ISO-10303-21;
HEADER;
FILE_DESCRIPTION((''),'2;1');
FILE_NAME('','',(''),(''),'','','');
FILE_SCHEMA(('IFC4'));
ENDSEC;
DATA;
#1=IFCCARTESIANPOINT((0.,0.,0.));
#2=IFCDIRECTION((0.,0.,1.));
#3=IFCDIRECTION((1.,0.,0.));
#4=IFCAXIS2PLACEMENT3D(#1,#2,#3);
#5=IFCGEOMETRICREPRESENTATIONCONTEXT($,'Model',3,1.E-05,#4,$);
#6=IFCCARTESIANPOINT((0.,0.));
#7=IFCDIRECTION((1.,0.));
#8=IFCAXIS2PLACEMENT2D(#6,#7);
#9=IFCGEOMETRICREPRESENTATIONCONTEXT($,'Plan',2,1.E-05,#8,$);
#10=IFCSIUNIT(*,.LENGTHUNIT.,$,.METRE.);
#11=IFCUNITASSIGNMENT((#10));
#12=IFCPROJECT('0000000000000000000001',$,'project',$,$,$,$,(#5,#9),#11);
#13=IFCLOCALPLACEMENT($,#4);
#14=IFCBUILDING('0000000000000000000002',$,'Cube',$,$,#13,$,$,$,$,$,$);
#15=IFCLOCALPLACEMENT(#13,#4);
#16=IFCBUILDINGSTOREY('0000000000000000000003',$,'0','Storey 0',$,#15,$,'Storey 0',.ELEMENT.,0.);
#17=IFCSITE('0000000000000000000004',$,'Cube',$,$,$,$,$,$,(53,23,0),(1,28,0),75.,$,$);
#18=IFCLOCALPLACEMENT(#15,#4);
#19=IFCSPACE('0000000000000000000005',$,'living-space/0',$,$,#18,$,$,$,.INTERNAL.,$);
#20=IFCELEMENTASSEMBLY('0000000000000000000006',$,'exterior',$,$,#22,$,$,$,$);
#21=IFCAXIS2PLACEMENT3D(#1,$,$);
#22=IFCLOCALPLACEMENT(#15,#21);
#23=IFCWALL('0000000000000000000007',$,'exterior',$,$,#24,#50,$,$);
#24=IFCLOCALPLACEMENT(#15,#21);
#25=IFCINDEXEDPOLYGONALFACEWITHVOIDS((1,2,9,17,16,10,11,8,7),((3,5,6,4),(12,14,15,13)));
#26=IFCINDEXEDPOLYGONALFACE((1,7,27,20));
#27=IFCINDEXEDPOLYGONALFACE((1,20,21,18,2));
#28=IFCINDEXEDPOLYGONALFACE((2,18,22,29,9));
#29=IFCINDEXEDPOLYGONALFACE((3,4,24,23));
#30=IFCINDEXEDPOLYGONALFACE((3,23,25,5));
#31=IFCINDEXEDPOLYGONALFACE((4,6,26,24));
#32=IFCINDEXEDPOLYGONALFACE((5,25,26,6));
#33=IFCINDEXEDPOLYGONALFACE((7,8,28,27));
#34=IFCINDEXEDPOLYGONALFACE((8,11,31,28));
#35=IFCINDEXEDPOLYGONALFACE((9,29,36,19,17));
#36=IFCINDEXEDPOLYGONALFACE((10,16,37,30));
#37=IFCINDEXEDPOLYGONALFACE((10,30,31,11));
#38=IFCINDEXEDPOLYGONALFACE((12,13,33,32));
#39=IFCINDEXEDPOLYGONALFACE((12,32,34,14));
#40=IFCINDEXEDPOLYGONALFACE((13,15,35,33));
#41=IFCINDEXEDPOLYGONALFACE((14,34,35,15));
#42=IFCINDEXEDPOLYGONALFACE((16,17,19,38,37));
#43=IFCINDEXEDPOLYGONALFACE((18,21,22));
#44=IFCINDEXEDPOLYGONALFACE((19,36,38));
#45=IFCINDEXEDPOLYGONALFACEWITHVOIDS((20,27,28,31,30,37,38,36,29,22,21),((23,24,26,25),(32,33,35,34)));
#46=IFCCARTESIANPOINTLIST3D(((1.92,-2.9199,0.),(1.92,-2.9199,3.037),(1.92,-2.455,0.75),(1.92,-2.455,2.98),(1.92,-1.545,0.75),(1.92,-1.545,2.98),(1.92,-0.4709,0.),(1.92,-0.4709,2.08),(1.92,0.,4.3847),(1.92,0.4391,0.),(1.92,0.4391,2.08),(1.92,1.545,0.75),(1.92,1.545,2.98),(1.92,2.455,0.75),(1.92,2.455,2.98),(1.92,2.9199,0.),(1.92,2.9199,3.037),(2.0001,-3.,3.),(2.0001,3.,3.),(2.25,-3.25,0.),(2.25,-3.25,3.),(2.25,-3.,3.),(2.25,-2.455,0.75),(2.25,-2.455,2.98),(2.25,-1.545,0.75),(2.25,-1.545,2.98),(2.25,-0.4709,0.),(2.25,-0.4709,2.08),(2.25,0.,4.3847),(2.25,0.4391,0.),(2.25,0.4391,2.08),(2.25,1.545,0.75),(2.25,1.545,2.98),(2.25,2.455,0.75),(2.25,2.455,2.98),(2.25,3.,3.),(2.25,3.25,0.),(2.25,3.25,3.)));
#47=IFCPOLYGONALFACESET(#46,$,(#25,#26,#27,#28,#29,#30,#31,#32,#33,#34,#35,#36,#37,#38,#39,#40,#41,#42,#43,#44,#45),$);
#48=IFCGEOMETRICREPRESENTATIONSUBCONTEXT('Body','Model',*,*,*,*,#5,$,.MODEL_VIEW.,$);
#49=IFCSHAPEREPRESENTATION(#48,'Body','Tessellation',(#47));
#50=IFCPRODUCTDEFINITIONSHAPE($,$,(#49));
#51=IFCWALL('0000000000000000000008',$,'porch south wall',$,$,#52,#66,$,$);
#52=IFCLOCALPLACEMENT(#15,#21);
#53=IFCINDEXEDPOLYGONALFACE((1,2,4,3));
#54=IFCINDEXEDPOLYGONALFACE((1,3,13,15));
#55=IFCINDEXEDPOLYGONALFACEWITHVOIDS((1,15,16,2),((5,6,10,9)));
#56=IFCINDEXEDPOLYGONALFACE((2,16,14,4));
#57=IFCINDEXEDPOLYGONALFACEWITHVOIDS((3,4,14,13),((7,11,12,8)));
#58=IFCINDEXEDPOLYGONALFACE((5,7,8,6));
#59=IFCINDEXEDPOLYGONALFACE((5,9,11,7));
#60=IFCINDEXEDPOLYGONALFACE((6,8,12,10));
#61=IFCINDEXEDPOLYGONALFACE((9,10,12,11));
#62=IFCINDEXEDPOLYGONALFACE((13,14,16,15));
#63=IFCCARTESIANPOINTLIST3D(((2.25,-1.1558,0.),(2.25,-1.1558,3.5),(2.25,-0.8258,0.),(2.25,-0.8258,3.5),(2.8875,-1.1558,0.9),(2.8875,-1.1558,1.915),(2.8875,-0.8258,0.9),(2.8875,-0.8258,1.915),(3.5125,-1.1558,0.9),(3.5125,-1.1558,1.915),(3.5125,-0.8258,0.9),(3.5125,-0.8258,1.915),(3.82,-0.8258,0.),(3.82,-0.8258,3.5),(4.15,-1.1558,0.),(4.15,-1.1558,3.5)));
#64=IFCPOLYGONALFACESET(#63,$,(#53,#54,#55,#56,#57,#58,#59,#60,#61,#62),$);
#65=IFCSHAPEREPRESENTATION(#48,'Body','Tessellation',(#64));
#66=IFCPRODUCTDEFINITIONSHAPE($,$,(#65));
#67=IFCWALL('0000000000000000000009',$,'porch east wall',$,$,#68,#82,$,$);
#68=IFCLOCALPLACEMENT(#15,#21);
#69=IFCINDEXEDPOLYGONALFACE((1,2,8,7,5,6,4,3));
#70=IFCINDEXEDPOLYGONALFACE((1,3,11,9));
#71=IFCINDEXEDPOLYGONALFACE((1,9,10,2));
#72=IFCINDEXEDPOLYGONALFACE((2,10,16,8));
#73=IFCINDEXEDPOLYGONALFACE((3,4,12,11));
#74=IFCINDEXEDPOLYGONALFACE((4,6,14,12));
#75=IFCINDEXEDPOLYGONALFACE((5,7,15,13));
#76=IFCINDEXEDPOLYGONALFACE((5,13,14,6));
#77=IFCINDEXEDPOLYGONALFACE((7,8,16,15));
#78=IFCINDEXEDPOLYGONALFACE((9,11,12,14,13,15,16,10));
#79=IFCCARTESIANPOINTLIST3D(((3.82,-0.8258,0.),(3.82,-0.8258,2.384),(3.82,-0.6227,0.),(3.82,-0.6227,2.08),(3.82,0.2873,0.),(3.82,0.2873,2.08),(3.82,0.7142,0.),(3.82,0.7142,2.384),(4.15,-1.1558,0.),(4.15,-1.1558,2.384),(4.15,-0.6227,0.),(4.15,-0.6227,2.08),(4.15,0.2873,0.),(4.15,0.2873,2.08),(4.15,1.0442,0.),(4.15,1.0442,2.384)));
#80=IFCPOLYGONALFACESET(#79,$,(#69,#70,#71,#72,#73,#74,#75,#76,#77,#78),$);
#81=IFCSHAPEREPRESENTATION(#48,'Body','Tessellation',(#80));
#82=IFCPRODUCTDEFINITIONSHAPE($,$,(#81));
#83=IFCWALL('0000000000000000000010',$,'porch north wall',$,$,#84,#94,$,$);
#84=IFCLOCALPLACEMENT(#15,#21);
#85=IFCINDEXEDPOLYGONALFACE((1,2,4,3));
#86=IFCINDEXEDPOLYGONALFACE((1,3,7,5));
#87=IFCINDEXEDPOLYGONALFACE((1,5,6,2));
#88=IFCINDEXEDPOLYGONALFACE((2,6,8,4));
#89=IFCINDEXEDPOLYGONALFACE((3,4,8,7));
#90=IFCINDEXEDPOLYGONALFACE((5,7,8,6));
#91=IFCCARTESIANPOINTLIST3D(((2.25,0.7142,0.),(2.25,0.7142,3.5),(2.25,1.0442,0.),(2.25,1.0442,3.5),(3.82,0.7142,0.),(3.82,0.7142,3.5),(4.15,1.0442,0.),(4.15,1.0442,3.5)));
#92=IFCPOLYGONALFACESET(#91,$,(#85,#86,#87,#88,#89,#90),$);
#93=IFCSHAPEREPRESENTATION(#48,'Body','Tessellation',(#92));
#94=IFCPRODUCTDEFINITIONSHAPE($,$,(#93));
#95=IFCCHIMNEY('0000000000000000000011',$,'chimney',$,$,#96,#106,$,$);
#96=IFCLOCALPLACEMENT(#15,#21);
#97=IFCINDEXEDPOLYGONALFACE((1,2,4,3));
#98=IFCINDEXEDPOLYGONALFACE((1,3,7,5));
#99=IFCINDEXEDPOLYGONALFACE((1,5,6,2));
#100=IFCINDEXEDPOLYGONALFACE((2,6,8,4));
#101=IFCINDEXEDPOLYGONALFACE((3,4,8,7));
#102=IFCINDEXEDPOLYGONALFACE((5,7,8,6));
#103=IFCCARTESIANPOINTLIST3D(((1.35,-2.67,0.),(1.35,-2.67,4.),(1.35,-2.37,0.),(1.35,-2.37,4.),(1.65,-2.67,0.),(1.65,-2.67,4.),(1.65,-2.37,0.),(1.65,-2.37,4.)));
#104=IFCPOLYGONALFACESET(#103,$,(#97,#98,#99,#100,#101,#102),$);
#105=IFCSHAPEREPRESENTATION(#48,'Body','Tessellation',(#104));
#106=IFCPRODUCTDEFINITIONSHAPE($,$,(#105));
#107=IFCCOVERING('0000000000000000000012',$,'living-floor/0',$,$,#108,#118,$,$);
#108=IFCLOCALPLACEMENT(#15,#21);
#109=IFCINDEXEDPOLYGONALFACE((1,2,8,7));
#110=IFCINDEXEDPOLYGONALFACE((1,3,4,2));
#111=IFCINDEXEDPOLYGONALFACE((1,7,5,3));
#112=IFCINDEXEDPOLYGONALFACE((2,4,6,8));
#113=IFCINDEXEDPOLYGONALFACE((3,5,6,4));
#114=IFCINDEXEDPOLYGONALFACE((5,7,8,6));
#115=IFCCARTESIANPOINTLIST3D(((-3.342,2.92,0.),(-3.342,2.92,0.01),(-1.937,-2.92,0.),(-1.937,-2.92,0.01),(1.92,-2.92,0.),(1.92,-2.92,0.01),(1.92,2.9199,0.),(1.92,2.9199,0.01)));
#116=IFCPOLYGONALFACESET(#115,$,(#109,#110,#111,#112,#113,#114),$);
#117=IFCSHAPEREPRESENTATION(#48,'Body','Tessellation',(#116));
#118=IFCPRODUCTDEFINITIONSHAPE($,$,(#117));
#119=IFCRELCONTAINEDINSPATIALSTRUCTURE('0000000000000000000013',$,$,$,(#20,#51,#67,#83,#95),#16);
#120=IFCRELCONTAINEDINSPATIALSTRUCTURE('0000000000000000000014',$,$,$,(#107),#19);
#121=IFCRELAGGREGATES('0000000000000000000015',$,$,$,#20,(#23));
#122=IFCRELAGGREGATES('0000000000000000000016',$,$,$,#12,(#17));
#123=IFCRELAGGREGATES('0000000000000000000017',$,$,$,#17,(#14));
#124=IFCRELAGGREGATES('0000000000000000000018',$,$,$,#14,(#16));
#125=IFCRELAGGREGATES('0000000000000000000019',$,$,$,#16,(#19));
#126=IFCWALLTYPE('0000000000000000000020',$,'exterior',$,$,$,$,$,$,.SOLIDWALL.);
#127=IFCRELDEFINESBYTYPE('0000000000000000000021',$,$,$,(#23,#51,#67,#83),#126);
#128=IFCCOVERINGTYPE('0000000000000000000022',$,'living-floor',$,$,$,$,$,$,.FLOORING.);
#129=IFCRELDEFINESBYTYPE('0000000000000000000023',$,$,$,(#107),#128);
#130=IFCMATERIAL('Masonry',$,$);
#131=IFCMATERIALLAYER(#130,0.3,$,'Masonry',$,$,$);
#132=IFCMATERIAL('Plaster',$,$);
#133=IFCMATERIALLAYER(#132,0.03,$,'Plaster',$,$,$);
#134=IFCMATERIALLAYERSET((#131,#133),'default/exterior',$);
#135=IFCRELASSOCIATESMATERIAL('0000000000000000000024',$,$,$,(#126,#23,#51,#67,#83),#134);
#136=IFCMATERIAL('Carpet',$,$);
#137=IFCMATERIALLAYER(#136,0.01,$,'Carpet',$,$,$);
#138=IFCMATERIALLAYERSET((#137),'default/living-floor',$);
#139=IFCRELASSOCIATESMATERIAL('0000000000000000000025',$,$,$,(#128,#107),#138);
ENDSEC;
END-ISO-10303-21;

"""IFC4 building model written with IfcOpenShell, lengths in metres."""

from ifc_helpers import new_model, si_unit, frame, origin, origin_with_axes, origin_2d_with_axis, place, context, subcontext, project, spatial, polyline, line, indexed_curve, outline, extrude, clip, bounded_halfspace, source, transform, mapped, material, layer, layer_set, layer_usage, type_object, element, aggregate, save


model = new_model("IFC4")

# Units and contexts
model_context = context("Model", 3, precision=1e-05, world=origin_with_axes())
plan_context = context("Plan", 2, precision=1e-05, world=origin_2d_with_axis())
body_context_1 = subcontext(model_context, "Body", "Model", "MODEL_VIEW")
ifc_project = project(units=[si_unit("LENGTHUNIT", "METRE")], contexts=[model_context, plan_context])

# Site, building, storey
site = spatial("IfcSite", under=ifc_project, Name="Cube", RefLatitude=(53, 23, 0), RefLongitude=(1, 28, 0), RefElevation=75.0)
building_placement = place(None, origin_with_axes())
building = spatial("IfcBuilding", under=site, at=building_placement, Name="Cube")
storey_placement = place(building_placement, origin_with_axes())
storey = spatial("IfcBuildingStorey", under=building, at=storey_placement, Name="0", Description="Storey 0", LongName="Storey 0", CompositionType="ELEMENT", Elevation=0.0)

# Element assembly, wall, openings
ifc_material_1 = material(Name="Masonry")
ifc_layer_1 = layer(ifc_material_1, 0.3, Name="Masonry")
ifc_material_2 = material(Name="Plaster")
ifc_layer_2 = layer(ifc_material_2, 0.03, Name="Plaster")
ifc_layer_set_1 = layer_set([ifc_layer_1, ifc_layer_2], Name="default/exterior")
wall_type = type_object("IfcWallType", Name="exterior", PredefinedType="SOLIDWALL", material=ifc_layer_set_1)
assembly_1_placement = place(storey_placement, frame((2.0, -3.0, 0.0), z_axis=(0.0, 0.0, 1.0), x_axis=(0.0, 1.0, 0.0)))
assembly_1 = element("IfcElementAssembly", 1, at=assembly_1_placement, inside=storey, Name="exterior")
ifc_layer_usage_1 = layer_usage(ifc_layer_set_1, "AXIS2", "POSITIVE", -0.25)
wall_1_placement = place(assembly_1_placement, origin_with_axes())
wall_1 = element("IfcWall", 2, at=wall_1_placement, type_object=wall_type, material=ifc_layer_usage_1, Name="exterior", context=body_context_1, shape_type="Clipping", body=[
    clip(clip(clip(clip(extrude(outline(polyline([(0.0801, 0.08), (-0.25, -0.25), (6.25, -0.25), (5.9199, 0.08), (0.0801, 0.08)])), origin(), (0.0, 0.0, 1.0), 4.385), bounded_halfspace(frame((6.0, 0.0, 3.0), z_axis=(0.419069, 0.0, 0.907954), x_axis=(0.0, -1.0, 0.0)), False, origin(), polyline([(6.0, -1.0), (3.0, -1.0), (3.0, 1.0), (6.0, 1.0), (6.0, -1.0)]))), bounded_halfspace(frame((6.0, 0.0, 3.0), z_axis=(0.0, 0.0, 1.0), x_axis=(0.0, 1.0, 0.0)), False, origin(), polyline([(6.0, 1.0), (7.0, 1.0), (7.0, -1.0), (6.0, -1.0), (6.0, 1.0)]))), bounded_halfspace(frame((3.0, 0.0, 4.3847), z_axis=(-0.419069, 0.0, 0.907954), x_axis=(0.0, -1.0, 0.0)), False, origin(), polyline([(3.0, -1.0), (0.0, -1.0), (0.0, 1.0), (3.0, 1.0), (3.0, -1.0)]))), bounded_halfspace(frame((0.0, 0.0, 3.0), z_axis=(0.0, 0.0, 1.0), x_axis=(0.0, -1.0, 0.0)), False, origin(), polyline([(0.0, -1.0), (-1.0, -1.0), (-1.0, 1.0), (0.0, 1.0), (0.0, -1.0)]))),
])
opening_1_placement = place(wall_1_placement, frame((0.545, -0.25, 0.75), z_axis=(0.0, 0.0, 1.0), x_axis=(1.0, 0.0, 0.0)))
element("IfcOpeningElement", 3, at=opening_1_placement, cuts=wall_1, PredefinedType="OPENING", context=body_context_1, shape_type="SweptSolid", body=[
    extrude(outline(polyline([(0.0, -0.02), (0.91, -0.02), (0.91, 0.35), (0.0, 0.35), (0.0, -0.02)])), origin(), (0.0, 0.0, 1.0), 2.23),
])
opening_2_placement = place(wall_1_placement, frame((4.545, -0.25, 0.75), z_axis=(0.0, 0.0, 1.0), x_axis=(1.0, 0.0, 0.0)))
element("IfcOpeningElement", 4, at=opening_2_placement, cuts=wall_1, PredefinedType="OPENING", context=body_context_1, shape_type="SweptSolid", body=[
    extrude(outline(polyline([(0.0, -0.02), (0.91, -0.02), (0.91, 0.35), (0.0, 0.35), (0.0, -0.02)])), origin(), (0.0, 0.0, 1.0), 2.23),
])
shared_shape_1 = source(origin_with_axes(), body_context_1, "Body", "SweptSolid", [
    extrude(outline(indexed_curve([(0.0, 0.0), (0.91, 0.0), (0.91, 2.08), (0.0, 2.08)], segments=[line(1, 2, 3, 4, 1)])), frame((0.0, -0.6, 0.0), z_axis=(0.0, -1.0, 0.0), x_axis=(1.0, 0.0, 0.0)), (0.0, 0.0, -1.0), 1.2),
])
opening_3_placement = place(wall_1_placement, frame((2.5291, -0.25, 0.0), z_axis=(0.0, 0.0, 1.0), x_axis=(1.0, 0.0, 0.0)))
element("IfcOpeningElement", 5, at=opening_3_placement, cuts=wall_1, PredefinedType="OPENING", context=body_context_1, shape_type="MappedRepresentation", body=[
    mapped(shared_shape_1, transform((0.0, 0.0, 0.0), x_axis=(1.0, 0.0, 0.0), y_axis=(0.0, 1.0, 0.0), z_axis=(0.0, 0.0, 1.0), scale=1.0)),
])
aggregate(assembly_1, [wall_1])

# Walls, openings
ifc_layer_usage_2 = layer_usage(ifc_layer_set_1, "AXIS2", "POSITIVE", 0.0)
wall_2_placement = place(storey_placement, frame((2.25, -1.1558, 0.0), z_axis=(0.0, 0.0, 1.0), x_axis=(1.0, 0.0, 0.0)))
wall_2 = element("IfcWall", 6, at=wall_2_placement, inside=storey, type_object=wall_type, material=ifc_layer_usage_2, Name="porch south wall", context=body_context_1, shape_type="SweptSolid", body=[
    extrude(outline(indexed_curve([(0.0, 0.0), (0.0, 0.33), (1.57, 0.33), (1.9, 0.0)], segments=[line(1, 2, 3, 4, 1)])), origin_with_axes(), (0.0, 0.0, 1.0), 3.5),
])
opening_4_placement = place(wall_2_placement, frame((0.6375, -0.0002, 0.9), z_axis=(0.0, 0.0, 1.0), x_axis=(1.0, 0.0, 0.0)))
element("IfcOpeningElement", 7, at=opening_4_placement, cuts=wall_2, context=body_context_1, shape_type="SweptSolid", body=[
    extrude(outline(indexed_curve([(0.0, 0.0), (0.0, 0.5), (0.625, 0.5), (0.625, 0.0), (0.0, 0.0)], self_intersect=False)), origin_with_axes(), (0.0, 0.0, 1.0), 1.015),
])
ifc_layer_usage_3 = layer_usage(ifc_layer_set_1, "AXIS2", "POSITIVE", 0.0)
wall_3_placement = place(storey_placement, frame((4.15, -1.1558, 0.0), z_axis=(0.0, 0.0, 1.0), x_axis=(0.0, 1.0, 0.0)))
wall_3 = element("IfcWall", 8, at=wall_3_placement, inside=storey, type_object=wall_type, material=ifc_layer_usage_3, Name="porch east wall", context=body_context_1, shape_type="SweptSolid", body=[
    extrude(outline(indexed_curve([(0.0, 0.0), (0.33, 0.33), (1.87, 0.33), (2.2, 0.0)], segments=[line(1, 2, 3, 4, 1)])), origin_with_axes(), (0.0, 0.0, 1.0), 2.384),
])
shared_shape_2 = source(origin_with_axes(), body_context_1, "Body", "SweptSolid", [
    extrude(outline(indexed_curve([(0.0, 0.0), (0.91, 0.0), (0.91, 2.08), (0.0, 2.08)], segments=[line(1, 2, 3, 4, 1)])), frame((0.0, -0.6, 0.0), z_axis=(0.0, -1.0, 0.0), x_axis=(1.0, 0.0, 0.0)), (0.0, 0.0, -1.0), 1.2),
])
opening_5_placement = place(wall_3_placement, frame((0.5331, 0.0, 0.0), z_axis=(0.0, 0.0, 1.0), x_axis=(1.0, 0.0, 0.0)))
element("IfcOpeningElement", 9, at=opening_5_placement, cuts=wall_3, PredefinedType="OPENING", context=body_context_1, shape_type="MappedRepresentation", body=[
    mapped(shared_shape_2, transform((0.0, 0.0, 0.0), x_axis=(1.0, 0.0, 0.0), y_axis=(0.0, 1.0, 0.0), z_axis=(0.0, 0.0, 1.0), scale=1.0)),
])

# Wall
ifc_layer_usage_4 = layer_usage(ifc_layer_set_1, "AXIS2", "POSITIVE", 0.0)
wall_4_placement = place(storey_placement, frame((4.15, 1.0442, 0.0), z_axis=(0.0, 0.0, 1.0), x_axis=(-1.0, 0.0, 0.0)))
element("IfcWall", 10, at=wall_4_placement, inside=storey, type_object=wall_type, material=ifc_layer_usage_4, Name="porch north wall", context=body_context_1, shape_type="SweptSolid", body=[
    extrude(outline(indexed_curve([(0.0, 0.0), (0.33, 0.33), (1.9, 0.33), (1.9, 0.0)], segments=[line(1, 2, 3, 4, 1)])), origin_with_axes(), (0.0, 0.0, 1.0), 3.5),
])

# Chimney
chimney_placement = place(storey_placement, frame((1.35, -2.67, 0.0), z_axis=(0.0, 0.0, 1.0), x_axis=(1.0, 0.0, 0.0)))
element("IfcChimney", 11, at=chimney_placement, inside=storey, Name="chimney", context=body_context_1, shape_type="SweptSolid", body=[
    extrude(outline(indexed_curve([(0.0, 0.0), (0.3, 0.0), (0.3, 0.3), (0.0, 0.3)])), None, (0.0, 0.0, 1.0), 4.0),
])

# Shared definitions
space_placement = place(storey_placement, origin_with_axes())
space = spatial("IfcSpace", under=storey, at=space_placement, Name="living-space/0", PredefinedType="INTERNAL")

# Covering
ifc_material_3 = material(Name="Carpet")
ifc_layer_3 = layer(ifc_material_3, 0.01, Name="Carpet")
ifc_layer_set_2 = layer_set([ifc_layer_3], Name="default/living-floor")
ifc_layer_usage_5 = layer_usage(ifc_layer_set_2, "AXIS3", "POSITIVE", 0.0)
covering_type = type_object("IfcCoveringType", Name="living-floor", PredefinedType="FLOORING", material=ifc_layer_set_2)
covering_placement = place(space_placement, origin_with_axes())
element("IfcCovering", 12, at=covering_placement, inside=space, type_object=covering_type, material=ifc_layer_usage_5, Name="living-floor/0", context=body_context_1, shape_type="SweptSolid", body=[
    extrude(outline(polyline([(1.92, 2.9199), (-3.342, 2.92), (-1.937, -2.92), (1.92, -2.92), (1.92, 2.9199)])), origin_with_axes(), (0.0, 0.0, 1.0), 0.01),
])

save(model, "model.ifc")
